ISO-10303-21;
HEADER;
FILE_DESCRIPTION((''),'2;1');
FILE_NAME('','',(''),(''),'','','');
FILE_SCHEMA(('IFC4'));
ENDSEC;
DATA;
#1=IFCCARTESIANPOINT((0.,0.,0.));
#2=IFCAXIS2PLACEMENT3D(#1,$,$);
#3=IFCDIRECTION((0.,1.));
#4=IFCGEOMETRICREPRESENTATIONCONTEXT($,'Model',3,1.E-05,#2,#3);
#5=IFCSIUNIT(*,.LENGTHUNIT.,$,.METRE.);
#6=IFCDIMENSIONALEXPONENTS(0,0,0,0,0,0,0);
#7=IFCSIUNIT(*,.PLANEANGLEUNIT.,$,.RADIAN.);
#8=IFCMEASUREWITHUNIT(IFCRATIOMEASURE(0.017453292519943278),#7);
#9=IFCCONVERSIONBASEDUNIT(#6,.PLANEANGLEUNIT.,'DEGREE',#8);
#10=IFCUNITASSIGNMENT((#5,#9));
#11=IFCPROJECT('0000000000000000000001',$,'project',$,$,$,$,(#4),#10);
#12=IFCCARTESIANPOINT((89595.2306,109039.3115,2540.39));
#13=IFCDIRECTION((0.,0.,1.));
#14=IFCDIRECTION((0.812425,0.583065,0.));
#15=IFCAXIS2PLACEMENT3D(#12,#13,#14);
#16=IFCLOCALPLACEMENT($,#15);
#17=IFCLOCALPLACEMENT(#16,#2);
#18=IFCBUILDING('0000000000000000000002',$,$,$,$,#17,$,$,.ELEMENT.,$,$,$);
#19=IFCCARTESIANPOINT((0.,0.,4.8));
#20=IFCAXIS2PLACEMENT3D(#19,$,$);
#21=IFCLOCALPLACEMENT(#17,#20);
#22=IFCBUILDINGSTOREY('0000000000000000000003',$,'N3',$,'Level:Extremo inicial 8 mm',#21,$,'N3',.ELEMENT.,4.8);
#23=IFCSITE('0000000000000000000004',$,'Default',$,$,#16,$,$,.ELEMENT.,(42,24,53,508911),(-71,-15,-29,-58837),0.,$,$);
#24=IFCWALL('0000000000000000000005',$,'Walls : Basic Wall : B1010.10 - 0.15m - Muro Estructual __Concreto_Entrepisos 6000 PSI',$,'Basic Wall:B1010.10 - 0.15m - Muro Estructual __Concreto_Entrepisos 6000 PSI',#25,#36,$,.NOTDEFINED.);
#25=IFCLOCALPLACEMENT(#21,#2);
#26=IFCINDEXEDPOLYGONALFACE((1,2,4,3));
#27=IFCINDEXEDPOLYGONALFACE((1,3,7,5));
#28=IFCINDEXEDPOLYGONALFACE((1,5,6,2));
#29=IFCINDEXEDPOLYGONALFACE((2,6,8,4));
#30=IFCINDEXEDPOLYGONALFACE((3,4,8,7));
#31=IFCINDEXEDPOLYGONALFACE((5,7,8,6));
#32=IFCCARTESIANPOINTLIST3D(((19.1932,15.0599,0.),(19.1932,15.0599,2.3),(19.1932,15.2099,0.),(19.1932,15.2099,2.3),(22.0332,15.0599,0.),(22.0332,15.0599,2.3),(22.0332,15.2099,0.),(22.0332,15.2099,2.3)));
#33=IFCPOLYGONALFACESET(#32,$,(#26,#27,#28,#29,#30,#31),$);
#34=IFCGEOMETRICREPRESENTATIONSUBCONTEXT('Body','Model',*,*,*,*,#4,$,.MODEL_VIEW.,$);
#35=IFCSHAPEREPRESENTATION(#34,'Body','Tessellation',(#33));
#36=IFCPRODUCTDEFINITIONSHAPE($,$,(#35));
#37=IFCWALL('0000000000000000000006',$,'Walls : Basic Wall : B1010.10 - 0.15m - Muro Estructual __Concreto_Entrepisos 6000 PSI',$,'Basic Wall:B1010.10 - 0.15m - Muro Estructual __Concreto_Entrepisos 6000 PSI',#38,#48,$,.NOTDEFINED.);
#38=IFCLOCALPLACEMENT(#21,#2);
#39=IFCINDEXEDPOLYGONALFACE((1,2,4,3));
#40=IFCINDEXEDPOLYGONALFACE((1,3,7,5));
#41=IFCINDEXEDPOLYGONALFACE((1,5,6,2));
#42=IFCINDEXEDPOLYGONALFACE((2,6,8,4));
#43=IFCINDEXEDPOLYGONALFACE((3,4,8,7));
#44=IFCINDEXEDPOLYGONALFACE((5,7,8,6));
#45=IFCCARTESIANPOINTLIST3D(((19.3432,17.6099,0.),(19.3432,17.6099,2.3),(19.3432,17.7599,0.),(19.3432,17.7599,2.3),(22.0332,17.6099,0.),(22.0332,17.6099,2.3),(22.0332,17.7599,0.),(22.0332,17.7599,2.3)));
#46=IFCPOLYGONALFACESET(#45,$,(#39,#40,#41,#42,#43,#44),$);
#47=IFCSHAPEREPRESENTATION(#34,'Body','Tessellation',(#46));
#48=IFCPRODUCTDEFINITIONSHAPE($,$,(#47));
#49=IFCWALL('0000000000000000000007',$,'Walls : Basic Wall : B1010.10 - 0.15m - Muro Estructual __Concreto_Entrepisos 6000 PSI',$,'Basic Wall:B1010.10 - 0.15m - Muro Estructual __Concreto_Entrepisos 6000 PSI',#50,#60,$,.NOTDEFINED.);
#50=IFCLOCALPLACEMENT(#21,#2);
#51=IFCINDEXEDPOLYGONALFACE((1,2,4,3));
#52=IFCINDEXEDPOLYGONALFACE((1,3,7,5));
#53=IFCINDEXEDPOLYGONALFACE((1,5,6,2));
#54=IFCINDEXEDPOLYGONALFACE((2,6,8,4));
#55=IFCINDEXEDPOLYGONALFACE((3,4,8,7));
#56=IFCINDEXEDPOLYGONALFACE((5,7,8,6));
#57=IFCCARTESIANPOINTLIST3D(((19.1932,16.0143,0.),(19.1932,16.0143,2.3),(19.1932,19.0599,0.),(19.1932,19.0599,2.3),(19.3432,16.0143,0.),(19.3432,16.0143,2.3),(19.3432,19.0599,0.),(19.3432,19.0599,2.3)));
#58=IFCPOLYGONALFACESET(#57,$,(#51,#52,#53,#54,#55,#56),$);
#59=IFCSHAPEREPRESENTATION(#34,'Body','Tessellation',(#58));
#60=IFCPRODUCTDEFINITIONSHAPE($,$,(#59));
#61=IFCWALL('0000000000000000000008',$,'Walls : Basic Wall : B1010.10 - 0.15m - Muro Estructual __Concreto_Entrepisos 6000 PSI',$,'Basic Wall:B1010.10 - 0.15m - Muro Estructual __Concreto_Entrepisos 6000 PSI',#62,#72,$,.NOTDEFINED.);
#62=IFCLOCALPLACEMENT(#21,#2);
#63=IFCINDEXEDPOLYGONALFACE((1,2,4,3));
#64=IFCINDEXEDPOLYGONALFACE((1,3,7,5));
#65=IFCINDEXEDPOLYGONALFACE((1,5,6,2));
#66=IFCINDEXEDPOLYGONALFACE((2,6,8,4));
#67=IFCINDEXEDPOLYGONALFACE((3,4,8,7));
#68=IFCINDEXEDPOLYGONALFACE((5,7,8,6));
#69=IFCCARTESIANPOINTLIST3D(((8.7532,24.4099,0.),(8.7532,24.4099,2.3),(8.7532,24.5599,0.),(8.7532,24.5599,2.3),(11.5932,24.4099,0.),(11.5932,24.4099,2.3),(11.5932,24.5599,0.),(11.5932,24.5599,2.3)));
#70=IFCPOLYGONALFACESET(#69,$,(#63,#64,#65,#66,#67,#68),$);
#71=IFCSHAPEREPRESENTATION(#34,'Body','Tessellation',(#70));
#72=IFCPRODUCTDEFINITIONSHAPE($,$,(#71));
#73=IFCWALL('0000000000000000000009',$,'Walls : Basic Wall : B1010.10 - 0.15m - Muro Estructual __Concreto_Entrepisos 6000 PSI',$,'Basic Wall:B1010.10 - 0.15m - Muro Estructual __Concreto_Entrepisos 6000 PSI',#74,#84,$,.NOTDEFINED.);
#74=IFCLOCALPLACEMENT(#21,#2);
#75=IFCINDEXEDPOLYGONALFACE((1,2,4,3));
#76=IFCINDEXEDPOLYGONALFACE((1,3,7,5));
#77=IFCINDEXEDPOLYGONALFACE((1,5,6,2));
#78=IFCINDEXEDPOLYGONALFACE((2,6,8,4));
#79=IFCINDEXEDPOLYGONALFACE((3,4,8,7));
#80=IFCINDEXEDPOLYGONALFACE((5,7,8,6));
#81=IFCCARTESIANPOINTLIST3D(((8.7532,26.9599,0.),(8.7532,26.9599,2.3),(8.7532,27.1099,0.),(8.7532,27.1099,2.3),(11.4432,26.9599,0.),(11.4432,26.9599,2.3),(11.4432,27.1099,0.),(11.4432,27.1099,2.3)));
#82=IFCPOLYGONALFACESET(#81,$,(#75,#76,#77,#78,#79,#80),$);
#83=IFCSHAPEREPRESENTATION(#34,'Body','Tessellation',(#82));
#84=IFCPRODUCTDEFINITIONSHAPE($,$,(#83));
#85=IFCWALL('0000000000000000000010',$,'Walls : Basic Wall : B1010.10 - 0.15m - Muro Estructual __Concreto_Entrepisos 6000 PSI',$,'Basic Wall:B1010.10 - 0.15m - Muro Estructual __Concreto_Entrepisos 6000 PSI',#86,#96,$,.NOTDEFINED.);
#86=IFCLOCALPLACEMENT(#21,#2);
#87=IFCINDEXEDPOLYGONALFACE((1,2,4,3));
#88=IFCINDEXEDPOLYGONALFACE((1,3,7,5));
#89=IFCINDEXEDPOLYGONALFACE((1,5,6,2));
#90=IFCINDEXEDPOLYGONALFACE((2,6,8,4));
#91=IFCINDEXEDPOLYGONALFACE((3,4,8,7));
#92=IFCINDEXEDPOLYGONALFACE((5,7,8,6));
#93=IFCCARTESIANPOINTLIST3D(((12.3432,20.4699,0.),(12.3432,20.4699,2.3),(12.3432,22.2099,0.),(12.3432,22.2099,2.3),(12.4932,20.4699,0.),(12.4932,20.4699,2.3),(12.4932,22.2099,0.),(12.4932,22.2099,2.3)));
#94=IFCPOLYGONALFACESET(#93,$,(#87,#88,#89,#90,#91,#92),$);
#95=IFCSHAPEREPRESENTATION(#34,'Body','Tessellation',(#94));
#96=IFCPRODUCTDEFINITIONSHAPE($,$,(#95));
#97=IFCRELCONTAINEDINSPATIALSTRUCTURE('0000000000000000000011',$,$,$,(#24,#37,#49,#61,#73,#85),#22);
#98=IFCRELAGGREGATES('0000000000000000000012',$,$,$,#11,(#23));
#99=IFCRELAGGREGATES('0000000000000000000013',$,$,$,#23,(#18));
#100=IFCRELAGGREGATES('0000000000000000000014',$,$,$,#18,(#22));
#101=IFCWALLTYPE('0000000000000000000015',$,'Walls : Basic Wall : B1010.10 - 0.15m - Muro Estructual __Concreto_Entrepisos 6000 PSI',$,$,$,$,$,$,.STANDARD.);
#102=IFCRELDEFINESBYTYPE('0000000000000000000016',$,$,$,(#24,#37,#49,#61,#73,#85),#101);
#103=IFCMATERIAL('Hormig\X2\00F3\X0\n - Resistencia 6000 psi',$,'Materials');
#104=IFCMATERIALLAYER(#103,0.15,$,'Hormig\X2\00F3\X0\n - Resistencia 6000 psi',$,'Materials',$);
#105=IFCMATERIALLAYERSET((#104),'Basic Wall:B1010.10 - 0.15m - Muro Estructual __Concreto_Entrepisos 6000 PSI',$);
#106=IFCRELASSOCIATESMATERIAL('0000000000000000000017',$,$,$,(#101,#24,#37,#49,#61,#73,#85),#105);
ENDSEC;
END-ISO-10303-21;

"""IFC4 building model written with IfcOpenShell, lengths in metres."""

from ifc_helpers import new_model, entity, si_unit, converted_unit, direction, frame, frame_2d, origin, place, context, subcontext, project, spatial, rectangle, extrude, material, layer, layer_set, layer_usage, type_object, element, save


model = new_model("IFC4")

# Units and contexts
model_context = context("Model", 3, precision=1e-05, world=origin(), true_north=direction((0.0, 1.0)))
body_context = subcontext(model_context, "Body", "Model", "MODEL_VIEW")
ifc_project = project(units=[si_unit("LENGTHUNIT", "METRE"), converted_unit("PLANEANGLEUNIT", "DEGREE", entity("IfcRatioMeasure", 0.017453292519943278), si_unit("PLANEANGLEUNIT", "RADIAN"), dimensions=[0, 0, 0, 0, 0, 0, 0])], contexts=[model_context])

# Site, building, storey
site_placement = place(None, frame((89595.2306, 109039.3115, 2540.39), z_axis=(0.0, 0.0, 1.0), x_axis=(0.812425, 0.583065, 0.0)))
site = spatial("IfcSite", under=ifc_project, at=site_placement, Name="Default", CompositionType="ELEMENT", RefLatitude=(42, 24, 53, 508911), RefLongitude=(-71, -15, -29, -58837), RefElevation=0.0)
building_placement = place(site_placement, origin())
building = spatial("IfcBuilding", under=site, at=building_placement, CompositionType="ELEMENT")
storey_placement = place(building_placement, frame((0.0, 0.0, 4.8)))
storey = spatial("IfcBuildingStorey", under=building, at=storey_placement, Name="N3", ObjectType="Level:Extremo inicial 8 mm", LongName="N3", CompositionType="ELEMENT", Elevation=4.8)

# Walls
ifc_material = material(Name="Hormigón - Resistencia 6000 psi", Category="Materials")
ifc_layer_1 = layer(ifc_material, 0.15, Name="Hormigón - Resistencia 6000 psi", Category="Materials")
ifc_layer_set_1 = layer_set([ifc_layer_1], Name="Basic Wall:B1010.10 - 0.15m - Muro Estructual __Concreto_Entrepisos 6000 PSI")
ifc_layer_usage_1 = layer_usage(ifc_layer_set_1, "AXIS2", "NEGATIVE", 0.075)
wall_type_1 = type_object("IfcWallType", Name="Walls : Basic Wall : B1010.10 - 0.15m - Muro Estructual __Concreto_Entrepisos 6000 PSI", PredefinedType="STANDARD", material=ifc_layer_set_1)
wall_1_placement = place(storey_placement, frame((22.0332, 15.1349, 0.0), z_axis=(0.0, 0.0, 1.0), x_axis=(-1.0, 0.0, 0.0)))
element("IfcWall", 1, at=wall_1_placement, inside=storey, type_object=wall_type_1, material=ifc_layer_usage_1, Name="Walls : Basic Wall : B1010.10 - 0.15m - Muro Estructual __Concreto_Entrepisos 6000 PSI", ObjectType="Basic Wall:B1010.10 - 0.15m - Muro Estructual __Concreto_Entrepisos 6000 PSI", PredefinedType="NOTDEFINED", context=body_context, shape_type="SweptSolid", body=[
    extrude(rectangle(XDim=2.84, YDim=0.15, at=frame_2d((1.42, 0.0), x_axis=(-1.0, 0.0))), origin(), (0.0, 0.0, 1.0), 2.3),
])
ifc_layer_usage_2 = layer_usage(ifc_layer_set_1, "AXIS2", "NEGATIVE", 0.075)
wall_2_placement = place(storey_placement, frame((22.0332, 17.6849, 0.0), z_axis=(0.0, 0.0, 1.0), x_axis=(-1.0, 0.0, 0.0)))
element("IfcWall", 2, at=wall_2_placement, inside=storey, type_object=wall_type_1, material=ifc_layer_usage_2, Name="Walls : Basic Wall : B1010.10 - 0.15m - Muro Estructual __Concreto_Entrepisos 6000 PSI", ObjectType="Basic Wall:B1010.10 - 0.15m - Muro Estructual __Concreto_Entrepisos 6000 PSI", PredefinedType="NOTDEFINED", context=body_context, shape_type="SweptSolid", body=[
    extrude(rectangle(XDim=2.69, YDim=0.15, at=frame_2d((1.345, 0.0), x_axis=(-1.0, 0.0))), origin(), (0.0, 0.0, 1.0), 2.3),
])
ifc_layer_usage_3 = layer_usage(ifc_layer_set_1, "AXIS2", "NEGATIVE", 0.075)
wall_3_placement = place(storey_placement, frame((19.2682, 16.0143, 0.0), z_axis=(0.0, 0.0, 1.0), x_axis=(0.0, 1.0, 0.0)))
element("IfcWall", 3, at=wall_3_placement, inside=storey, type_object=wall_type_1, material=ifc_layer_usage_3, Name="Walls : Basic Wall : B1010.10 - 0.15m - Muro Estructual __Concreto_Entrepisos 6000 PSI", ObjectType="Basic Wall:B1010.10 - 0.15m - Muro Estructual __Concreto_Entrepisos 6000 PSI", PredefinedType="NOTDEFINED", context=body_context, shape_type="SweptSolid", body=[
    extrude(rectangle(XDim=3.0455, YDim=0.15, at=frame_2d((1.5228, 0.0), x_axis=(-1.0, 0.0))), origin(), (0.0, 0.0, 1.0), 2.3),
])
ifc_layer_usage_4 = layer_usage(ifc_layer_set_1, "AXIS2", "NEGATIVE", 0.075)
wall_4_placement = place(storey_placement, frame((8.7532, 24.4849, 0.0)))
element("IfcWall", 4, at=wall_4_placement, inside=storey, type_object=wall_type_1, material=ifc_layer_usage_4, Name="Walls : Basic Wall : B1010.10 - 0.15m - Muro Estructual __Concreto_Entrepisos 6000 PSI", ObjectType="Basic Wall:B1010.10 - 0.15m - Muro Estructual __Concreto_Entrepisos 6000 PSI", PredefinedType="NOTDEFINED", context=body_context, shape_type="SweptSolid", body=[
    extrude(rectangle(XDim=2.84, YDim=0.15, at=frame_2d((1.42, 0.0), x_axis=(-1.0, 0.0))), origin(), (0.0, 0.0, 1.0), 2.3),
])
ifc_layer_usage_5 = layer_usage(ifc_layer_set_1, "AXIS2", "NEGATIVE", 0.075)
wall_5_placement = place(storey_placement, frame((8.7532, 27.0349, 0.0)))
element("IfcWall", 5, at=wall_5_placement, inside=storey, type_object=wall_type_1, material=ifc_layer_usage_5, Name="Walls : Basic Wall : B1010.10 - 0.15m - Muro Estructual __Concreto_Entrepisos 6000 PSI", ObjectType="Basic Wall:B1010.10 - 0.15m - Muro Estructual __Concreto_Entrepisos 6000 PSI", PredefinedType="NOTDEFINED", context=body_context, shape_type="SweptSolid", body=[
    extrude(rectangle(XDim=2.69, YDim=0.15, at=frame_2d((1.345, 0.0), x_axis=(-1.0, 0.0))), origin(), (0.0, 0.0, 1.0), 2.3),
])
ifc_layer_usage_6 = layer_usage(ifc_layer_set_1, "AXIS2", "POSITIVE", -0.075)
wall_6_placement = place(storey_placement, frame((12.4182, 20.4699, 0.0), z_axis=(0.0, 0.0, 1.0), x_axis=(0.0, 1.0, 0.0)))
element("IfcWall", 6, at=wall_6_placement, inside=storey, type_object=wall_type_1, material=ifc_layer_usage_6, Name="Walls : Basic Wall : B1010.10 - 0.15m - Muro Estructual __Concreto_Entrepisos 6000 PSI", ObjectType="Basic Wall:B1010.10 - 0.15m - Muro Estructual __Concreto_Entrepisos 6000 PSI", PredefinedType="NOTDEFINED", context=body_context, shape_type="SweptSolid", body=[
    extrude(rectangle(XDim=1.74, YDim=0.15, at=frame_2d((0.87, 0.0), x_axis=(-1.0, 0.0))), origin(), (0.0, 0.0, 1.0), 2.3),
])

save(model, "model.ifc")
